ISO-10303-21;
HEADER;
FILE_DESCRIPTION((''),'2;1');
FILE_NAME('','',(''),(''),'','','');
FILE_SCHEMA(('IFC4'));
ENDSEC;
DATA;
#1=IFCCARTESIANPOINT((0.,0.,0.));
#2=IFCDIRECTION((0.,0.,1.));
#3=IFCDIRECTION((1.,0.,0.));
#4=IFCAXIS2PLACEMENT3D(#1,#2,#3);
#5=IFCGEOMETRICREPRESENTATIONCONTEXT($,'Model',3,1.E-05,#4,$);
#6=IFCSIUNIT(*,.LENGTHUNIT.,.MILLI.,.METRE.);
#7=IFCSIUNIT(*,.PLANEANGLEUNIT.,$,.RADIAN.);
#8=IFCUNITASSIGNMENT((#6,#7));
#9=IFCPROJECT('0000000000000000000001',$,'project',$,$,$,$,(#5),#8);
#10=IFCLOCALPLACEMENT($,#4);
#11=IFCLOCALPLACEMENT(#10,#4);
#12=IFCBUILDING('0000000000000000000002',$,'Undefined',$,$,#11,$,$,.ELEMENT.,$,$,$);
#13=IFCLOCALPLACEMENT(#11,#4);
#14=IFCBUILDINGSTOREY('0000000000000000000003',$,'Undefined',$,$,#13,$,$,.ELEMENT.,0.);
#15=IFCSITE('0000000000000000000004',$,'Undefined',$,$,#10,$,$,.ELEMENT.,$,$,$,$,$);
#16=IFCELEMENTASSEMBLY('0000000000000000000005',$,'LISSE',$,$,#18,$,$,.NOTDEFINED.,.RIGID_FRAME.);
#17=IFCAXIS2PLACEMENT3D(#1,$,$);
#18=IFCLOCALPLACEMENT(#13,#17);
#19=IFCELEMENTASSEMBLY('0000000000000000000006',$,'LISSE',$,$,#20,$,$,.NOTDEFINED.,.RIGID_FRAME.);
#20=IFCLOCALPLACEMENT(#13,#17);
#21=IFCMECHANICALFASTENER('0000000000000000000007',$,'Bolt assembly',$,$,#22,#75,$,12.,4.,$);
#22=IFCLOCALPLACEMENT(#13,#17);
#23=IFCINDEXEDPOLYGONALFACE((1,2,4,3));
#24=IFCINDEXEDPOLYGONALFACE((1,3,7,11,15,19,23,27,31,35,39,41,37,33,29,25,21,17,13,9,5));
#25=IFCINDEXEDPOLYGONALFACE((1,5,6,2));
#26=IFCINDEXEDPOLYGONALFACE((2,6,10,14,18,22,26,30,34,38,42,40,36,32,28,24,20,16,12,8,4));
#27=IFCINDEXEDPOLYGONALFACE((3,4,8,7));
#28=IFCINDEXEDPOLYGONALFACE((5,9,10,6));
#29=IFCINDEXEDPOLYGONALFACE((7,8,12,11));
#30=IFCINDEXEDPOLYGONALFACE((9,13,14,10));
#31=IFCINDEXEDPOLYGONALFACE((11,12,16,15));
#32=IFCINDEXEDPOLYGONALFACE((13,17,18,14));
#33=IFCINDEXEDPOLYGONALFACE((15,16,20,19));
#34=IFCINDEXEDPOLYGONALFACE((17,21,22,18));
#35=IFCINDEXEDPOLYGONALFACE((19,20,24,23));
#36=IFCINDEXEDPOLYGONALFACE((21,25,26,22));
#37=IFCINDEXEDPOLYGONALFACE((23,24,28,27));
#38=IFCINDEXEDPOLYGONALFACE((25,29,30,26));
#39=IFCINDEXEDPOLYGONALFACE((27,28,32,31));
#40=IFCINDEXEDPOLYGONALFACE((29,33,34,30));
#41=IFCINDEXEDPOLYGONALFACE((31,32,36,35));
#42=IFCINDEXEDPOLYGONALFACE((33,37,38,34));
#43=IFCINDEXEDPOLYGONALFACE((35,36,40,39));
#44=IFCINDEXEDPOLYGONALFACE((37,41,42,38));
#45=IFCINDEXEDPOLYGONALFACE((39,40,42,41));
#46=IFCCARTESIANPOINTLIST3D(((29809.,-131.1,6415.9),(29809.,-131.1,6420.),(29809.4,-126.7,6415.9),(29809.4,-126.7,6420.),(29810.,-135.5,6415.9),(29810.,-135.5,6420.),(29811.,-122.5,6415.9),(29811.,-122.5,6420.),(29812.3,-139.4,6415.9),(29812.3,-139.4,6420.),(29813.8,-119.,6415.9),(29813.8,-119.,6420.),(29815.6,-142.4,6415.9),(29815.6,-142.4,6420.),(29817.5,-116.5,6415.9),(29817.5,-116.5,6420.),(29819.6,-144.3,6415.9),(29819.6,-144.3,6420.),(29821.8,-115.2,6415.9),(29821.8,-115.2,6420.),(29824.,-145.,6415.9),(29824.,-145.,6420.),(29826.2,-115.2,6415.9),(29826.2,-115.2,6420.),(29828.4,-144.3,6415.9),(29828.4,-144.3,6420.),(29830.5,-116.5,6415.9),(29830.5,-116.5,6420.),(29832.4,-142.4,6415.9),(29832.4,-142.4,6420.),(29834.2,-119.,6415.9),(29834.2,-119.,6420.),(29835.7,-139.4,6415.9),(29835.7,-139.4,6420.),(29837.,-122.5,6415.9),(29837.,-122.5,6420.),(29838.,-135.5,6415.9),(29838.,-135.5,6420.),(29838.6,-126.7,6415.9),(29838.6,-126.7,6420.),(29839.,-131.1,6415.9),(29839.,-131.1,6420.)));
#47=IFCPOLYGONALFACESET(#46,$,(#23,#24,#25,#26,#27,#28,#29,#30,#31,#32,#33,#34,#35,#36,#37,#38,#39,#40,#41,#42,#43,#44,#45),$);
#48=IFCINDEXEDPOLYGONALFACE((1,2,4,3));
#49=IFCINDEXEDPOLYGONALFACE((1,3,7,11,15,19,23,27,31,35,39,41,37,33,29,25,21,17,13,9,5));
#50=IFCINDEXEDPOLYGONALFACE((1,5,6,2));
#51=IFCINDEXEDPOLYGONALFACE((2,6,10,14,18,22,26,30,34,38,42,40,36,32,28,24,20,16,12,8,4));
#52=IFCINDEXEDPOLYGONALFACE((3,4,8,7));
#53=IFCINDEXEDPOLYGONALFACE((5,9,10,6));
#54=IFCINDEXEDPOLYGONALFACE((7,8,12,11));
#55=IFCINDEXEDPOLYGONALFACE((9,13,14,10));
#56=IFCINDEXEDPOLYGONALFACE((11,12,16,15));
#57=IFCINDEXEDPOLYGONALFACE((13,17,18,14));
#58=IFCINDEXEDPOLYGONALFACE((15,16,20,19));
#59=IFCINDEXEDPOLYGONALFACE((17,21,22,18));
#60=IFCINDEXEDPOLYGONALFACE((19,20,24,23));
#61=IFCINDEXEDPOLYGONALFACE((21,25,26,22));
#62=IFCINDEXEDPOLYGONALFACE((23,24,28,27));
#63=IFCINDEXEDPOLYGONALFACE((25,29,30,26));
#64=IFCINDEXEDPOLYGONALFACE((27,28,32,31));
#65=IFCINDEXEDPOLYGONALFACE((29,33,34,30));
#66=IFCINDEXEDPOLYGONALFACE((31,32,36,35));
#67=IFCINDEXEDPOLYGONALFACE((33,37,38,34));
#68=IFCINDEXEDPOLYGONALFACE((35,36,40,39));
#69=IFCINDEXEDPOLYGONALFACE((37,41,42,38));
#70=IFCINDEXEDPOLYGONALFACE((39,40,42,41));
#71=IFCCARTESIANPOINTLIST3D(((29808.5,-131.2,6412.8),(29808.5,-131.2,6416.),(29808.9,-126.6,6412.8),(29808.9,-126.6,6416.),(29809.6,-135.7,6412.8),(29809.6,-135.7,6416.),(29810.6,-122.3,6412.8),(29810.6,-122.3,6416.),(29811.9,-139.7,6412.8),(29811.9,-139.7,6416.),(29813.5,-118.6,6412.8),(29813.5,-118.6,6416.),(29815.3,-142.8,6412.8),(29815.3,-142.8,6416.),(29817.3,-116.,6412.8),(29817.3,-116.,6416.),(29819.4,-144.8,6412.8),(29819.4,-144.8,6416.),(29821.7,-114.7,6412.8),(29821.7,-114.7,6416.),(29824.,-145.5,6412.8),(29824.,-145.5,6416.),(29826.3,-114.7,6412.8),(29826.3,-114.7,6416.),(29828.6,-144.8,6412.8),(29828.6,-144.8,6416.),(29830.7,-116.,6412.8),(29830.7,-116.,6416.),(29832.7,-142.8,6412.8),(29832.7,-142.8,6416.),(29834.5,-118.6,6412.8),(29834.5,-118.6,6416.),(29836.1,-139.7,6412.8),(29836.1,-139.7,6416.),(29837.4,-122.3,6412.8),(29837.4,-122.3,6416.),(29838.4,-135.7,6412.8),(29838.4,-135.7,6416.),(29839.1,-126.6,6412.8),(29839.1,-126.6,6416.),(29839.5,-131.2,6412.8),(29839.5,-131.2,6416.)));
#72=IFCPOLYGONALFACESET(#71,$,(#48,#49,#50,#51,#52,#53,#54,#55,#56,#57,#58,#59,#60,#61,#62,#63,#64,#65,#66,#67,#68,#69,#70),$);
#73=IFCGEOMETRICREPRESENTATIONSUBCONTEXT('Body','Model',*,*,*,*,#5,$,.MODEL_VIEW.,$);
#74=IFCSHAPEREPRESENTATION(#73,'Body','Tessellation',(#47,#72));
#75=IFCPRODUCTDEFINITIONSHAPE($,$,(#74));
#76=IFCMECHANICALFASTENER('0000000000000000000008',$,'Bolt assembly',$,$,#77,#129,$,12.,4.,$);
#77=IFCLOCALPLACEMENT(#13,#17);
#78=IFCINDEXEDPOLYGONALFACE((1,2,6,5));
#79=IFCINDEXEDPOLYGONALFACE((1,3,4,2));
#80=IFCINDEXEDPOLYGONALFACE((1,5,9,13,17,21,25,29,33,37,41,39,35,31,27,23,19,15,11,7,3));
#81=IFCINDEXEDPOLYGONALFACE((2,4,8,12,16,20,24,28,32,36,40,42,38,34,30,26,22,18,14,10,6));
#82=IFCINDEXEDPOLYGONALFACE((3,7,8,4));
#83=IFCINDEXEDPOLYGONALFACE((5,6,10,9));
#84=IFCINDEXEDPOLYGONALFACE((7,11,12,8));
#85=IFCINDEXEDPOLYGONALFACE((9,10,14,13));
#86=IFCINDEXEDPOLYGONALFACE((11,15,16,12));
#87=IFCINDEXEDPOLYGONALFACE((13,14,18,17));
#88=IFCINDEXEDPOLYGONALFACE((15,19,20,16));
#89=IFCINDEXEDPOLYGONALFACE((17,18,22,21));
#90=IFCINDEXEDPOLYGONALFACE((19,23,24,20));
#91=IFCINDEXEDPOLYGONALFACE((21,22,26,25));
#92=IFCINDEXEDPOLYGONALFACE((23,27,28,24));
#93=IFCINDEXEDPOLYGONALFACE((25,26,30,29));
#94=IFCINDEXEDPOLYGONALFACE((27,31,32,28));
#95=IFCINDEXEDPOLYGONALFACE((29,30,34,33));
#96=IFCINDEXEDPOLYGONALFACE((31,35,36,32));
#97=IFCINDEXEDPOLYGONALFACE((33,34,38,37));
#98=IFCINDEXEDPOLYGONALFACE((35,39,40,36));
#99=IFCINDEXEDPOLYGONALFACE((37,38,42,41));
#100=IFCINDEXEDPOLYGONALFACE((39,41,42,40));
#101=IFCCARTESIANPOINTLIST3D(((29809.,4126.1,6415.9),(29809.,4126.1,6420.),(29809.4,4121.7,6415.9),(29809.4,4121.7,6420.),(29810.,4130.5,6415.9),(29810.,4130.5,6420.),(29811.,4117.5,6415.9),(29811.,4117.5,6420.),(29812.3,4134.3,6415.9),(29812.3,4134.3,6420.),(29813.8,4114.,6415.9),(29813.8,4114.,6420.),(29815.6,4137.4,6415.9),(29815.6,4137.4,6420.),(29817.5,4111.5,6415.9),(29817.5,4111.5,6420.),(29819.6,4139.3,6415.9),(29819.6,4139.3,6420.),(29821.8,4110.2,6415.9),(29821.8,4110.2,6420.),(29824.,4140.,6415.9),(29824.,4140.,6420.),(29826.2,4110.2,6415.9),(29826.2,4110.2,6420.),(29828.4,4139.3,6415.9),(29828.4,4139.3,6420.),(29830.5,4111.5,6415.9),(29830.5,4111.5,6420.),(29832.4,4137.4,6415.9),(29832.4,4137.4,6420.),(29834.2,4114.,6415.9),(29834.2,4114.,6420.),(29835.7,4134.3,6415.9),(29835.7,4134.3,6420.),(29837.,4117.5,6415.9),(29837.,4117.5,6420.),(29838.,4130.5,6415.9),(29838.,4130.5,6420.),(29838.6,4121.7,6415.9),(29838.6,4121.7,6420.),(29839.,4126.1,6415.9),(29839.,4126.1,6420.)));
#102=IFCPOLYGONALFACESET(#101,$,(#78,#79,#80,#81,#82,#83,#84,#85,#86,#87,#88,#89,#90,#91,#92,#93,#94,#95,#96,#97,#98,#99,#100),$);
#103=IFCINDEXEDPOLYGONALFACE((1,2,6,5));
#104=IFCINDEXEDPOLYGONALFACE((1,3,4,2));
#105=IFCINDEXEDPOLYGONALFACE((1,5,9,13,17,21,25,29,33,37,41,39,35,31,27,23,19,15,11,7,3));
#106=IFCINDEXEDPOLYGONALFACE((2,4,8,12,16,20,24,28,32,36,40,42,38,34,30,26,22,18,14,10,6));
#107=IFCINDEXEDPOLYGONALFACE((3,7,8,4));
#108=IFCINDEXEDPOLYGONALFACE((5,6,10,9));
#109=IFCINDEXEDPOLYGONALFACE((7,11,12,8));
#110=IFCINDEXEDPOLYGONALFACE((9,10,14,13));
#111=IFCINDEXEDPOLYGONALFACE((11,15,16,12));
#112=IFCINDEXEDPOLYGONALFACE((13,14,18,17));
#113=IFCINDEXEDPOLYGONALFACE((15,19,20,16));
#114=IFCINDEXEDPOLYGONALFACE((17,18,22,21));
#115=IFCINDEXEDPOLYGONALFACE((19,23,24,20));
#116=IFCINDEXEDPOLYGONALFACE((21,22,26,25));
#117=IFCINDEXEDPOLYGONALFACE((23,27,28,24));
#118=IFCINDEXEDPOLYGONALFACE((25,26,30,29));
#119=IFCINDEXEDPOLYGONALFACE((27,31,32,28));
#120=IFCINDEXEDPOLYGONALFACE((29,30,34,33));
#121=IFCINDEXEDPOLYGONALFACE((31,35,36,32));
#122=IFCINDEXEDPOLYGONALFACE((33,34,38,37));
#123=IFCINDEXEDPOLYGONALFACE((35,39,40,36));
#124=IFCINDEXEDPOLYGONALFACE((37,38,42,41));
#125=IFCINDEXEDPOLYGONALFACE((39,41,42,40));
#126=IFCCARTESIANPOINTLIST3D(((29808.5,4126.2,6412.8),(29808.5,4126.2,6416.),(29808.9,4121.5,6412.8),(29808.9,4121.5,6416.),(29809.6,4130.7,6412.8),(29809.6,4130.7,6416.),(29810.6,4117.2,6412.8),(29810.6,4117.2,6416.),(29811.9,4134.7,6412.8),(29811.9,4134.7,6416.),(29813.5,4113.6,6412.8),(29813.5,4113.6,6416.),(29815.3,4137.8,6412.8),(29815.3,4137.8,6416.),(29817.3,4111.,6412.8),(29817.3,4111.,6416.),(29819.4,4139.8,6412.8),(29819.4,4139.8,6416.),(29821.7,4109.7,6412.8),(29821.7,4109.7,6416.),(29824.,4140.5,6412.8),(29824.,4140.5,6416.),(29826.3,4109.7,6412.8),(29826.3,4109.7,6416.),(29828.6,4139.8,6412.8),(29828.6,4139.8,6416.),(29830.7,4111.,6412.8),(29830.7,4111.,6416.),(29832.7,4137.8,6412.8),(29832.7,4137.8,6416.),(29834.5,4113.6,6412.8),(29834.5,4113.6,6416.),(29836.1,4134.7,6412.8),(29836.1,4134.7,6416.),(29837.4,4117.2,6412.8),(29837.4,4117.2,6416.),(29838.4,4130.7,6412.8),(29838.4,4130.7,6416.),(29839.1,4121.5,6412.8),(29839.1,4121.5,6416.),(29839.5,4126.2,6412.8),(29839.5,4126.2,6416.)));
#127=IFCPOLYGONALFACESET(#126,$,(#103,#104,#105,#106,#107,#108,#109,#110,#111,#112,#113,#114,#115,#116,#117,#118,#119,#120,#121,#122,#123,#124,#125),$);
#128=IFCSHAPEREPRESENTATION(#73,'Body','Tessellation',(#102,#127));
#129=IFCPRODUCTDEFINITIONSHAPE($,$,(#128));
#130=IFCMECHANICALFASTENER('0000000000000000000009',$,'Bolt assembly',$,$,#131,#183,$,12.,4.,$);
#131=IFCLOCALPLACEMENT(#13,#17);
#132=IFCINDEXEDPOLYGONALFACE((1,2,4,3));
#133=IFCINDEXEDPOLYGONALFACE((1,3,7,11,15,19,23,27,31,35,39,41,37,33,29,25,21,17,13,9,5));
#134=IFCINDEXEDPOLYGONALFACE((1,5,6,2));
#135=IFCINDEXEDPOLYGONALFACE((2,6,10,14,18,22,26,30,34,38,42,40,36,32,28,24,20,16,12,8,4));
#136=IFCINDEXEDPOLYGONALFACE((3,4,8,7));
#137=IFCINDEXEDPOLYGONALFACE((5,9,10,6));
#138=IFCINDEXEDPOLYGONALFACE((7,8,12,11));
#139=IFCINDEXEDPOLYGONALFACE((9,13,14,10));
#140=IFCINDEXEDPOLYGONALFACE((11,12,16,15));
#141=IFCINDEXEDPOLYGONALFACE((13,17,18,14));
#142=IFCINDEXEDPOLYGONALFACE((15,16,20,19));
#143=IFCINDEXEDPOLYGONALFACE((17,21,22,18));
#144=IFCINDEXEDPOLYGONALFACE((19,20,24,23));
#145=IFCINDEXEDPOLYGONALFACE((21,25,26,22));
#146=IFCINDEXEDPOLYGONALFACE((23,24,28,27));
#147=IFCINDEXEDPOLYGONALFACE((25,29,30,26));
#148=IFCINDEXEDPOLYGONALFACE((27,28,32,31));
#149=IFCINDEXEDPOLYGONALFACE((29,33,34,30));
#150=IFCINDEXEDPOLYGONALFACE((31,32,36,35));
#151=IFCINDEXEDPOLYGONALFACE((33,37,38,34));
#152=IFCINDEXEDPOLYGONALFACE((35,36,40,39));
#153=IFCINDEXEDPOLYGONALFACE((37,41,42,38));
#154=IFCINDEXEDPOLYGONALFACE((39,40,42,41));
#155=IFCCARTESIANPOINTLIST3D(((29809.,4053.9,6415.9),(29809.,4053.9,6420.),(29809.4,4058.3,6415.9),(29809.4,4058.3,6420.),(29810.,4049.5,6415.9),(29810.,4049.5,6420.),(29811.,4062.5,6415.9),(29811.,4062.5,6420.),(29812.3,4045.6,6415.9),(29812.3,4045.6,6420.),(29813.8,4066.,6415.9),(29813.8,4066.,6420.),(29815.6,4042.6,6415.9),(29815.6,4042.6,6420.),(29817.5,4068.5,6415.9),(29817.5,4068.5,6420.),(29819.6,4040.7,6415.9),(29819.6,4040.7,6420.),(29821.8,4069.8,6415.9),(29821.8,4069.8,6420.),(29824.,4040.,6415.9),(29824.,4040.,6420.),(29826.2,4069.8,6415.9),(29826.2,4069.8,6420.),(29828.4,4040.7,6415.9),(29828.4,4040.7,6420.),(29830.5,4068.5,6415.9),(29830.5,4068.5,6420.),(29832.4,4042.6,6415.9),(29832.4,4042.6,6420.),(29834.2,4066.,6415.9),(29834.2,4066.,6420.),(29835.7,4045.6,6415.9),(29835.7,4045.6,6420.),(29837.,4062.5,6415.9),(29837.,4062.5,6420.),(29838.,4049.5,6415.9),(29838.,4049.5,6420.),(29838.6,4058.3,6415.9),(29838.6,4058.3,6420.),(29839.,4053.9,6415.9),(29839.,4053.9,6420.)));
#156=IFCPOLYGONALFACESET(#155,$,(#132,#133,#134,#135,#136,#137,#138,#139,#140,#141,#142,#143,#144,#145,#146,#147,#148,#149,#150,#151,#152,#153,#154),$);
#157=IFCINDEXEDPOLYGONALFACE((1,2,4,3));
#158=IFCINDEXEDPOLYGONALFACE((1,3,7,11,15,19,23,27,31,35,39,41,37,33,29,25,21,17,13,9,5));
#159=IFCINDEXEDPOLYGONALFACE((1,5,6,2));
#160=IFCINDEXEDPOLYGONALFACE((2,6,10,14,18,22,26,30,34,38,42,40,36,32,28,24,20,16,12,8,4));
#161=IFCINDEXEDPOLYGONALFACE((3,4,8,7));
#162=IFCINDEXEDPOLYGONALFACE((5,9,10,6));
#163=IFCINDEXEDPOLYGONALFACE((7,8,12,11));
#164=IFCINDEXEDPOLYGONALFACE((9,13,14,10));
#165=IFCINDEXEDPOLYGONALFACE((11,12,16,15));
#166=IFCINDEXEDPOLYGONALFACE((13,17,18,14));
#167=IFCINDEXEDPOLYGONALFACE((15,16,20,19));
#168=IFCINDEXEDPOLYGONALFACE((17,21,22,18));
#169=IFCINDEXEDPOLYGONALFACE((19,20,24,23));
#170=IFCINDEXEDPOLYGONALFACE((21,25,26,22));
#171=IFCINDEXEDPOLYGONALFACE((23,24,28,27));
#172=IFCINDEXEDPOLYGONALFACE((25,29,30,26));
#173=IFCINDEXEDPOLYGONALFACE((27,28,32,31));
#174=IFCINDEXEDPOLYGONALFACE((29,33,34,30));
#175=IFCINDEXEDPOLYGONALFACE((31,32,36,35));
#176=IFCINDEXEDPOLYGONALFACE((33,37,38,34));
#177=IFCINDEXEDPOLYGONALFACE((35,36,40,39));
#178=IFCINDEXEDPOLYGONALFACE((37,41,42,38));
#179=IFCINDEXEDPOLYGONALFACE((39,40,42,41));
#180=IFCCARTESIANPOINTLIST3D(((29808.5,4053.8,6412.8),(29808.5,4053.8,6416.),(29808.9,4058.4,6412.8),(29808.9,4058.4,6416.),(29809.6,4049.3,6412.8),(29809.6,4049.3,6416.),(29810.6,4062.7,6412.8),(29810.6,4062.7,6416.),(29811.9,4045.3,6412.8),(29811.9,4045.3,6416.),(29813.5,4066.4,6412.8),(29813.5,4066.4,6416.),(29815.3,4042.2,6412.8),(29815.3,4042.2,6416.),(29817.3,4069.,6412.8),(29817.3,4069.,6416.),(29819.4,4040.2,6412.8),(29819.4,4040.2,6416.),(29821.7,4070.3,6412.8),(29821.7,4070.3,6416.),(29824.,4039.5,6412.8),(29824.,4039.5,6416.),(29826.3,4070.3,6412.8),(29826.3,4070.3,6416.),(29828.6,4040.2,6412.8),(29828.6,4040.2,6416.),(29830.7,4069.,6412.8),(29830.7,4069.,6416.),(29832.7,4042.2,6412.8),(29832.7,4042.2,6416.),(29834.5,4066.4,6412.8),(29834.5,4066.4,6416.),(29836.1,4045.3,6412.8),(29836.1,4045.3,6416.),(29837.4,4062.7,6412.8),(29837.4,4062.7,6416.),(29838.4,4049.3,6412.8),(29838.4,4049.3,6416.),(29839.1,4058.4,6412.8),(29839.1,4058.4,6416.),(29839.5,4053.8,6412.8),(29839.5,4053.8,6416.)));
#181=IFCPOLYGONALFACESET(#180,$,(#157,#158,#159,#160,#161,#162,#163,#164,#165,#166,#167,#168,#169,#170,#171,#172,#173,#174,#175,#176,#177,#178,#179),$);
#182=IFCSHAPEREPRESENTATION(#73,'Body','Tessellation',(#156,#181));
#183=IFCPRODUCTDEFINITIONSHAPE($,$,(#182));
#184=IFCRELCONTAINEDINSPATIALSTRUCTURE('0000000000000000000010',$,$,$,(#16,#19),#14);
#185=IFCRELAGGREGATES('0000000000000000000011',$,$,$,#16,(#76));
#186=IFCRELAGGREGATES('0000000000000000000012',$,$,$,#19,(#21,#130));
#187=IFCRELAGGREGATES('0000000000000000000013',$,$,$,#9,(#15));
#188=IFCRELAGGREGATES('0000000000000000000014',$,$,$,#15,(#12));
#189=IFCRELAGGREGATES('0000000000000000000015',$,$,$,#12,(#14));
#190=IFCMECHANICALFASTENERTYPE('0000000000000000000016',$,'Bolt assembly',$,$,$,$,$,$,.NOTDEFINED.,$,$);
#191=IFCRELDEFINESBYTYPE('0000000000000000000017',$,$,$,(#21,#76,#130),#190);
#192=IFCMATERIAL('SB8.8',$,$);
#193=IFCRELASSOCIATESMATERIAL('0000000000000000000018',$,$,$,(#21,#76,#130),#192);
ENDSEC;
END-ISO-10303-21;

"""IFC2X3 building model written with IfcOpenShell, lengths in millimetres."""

from ifc_helpers import new_model, si_unit, frame, origin_with_axes, origin_2d_with_axis, place, context, subcontext, project, spatial, circle, extrude, source, transform, mapped, material, type_object, element, aggregate, save


model = new_model("IFC2X3")

# Units and contexts
model_context = context("Model", 3, precision=1e-05, world=origin_with_axes())
body_context = subcontext(model_context, "Body", "Model", "MODEL_VIEW")
ifc_project = project(units=[si_unit("LENGTHUNIT", "METRE", prefix="MILLI"), si_unit("PLANEANGLEUNIT", "RADIAN")], contexts=[model_context])

# Site, building, storey
site_placement = place(None, origin_with_axes())
site = spatial("IfcSite", under=ifc_project, at=site_placement, Name="Undefined", CompositionType="ELEMENT")
building_placement = place(site_placement, origin_with_axes())
building = spatial("IfcBuilding", under=site, at=building_placement, Name="Undefined", CompositionType="ELEMENT")
storey_placement = place(building_placement, origin_with_axes())
storey = spatial("IfcBuildingStorey", under=building, at=storey_placement, Name="Undefined", CompositionType="ELEMENT", Elevation=0.0)

# Element assemblies
assembly_1_placement = place(storey_placement, origin_with_axes())
assembly_1 = element("IfcElementAssembly", 1, at=assembly_1_placement, inside=storey, Name="LISSE", AssemblyPlace="NOTDEFINED", PredefinedType="RIGID_FRAME")
assembly_2_placement = place(storey_placement, origin_with_axes())
assembly_2 = element("IfcElementAssembly", 2, at=assembly_2_placement, inside=storey, Name="LISSE", AssemblyPlace="NOTDEFINED", PredefinedType="RIGID_FRAME")

# Shared definitions
ifc_material_1 = material(Name="SB8.8")
mechanical_fastener_type = type_object("IfcMechanicalFastenerType", Name="Bolt assembly")

# Mechanical fasteners
shared_shape_1 = source(origin_with_axes(), body_context, "Body", "SweptSolid", [
    extrude(circle(Radius=15.0, at=origin_2d_with_axis()), frame((0.0, -10.0, 0.0), z_axis=(0.0, 1.0, 0.0), x_axis=(1.0, 0.0, 0.0)), (0.0, 0.0, 1.0), 4.1),
    extrude(circle(Radius=15.5, at=origin_2d_with_axis()), frame((0.0, -6.0, 0.0), z_axis=(0.0, 1.0, 0.0), x_axis=(1.0, 0.0, 0.0)), (0.0, 0.0, 1.0), 3.2),
])
mechanical_fastener_1_placement = place(assembly_2_placement, frame((29824.0, -130.0, 6410.0), z_axis=(1.0, 0.0, 0.0), x_axis=(0.0, -1.0, 0.0)))
mechanical_fastener_1 = element("IfcMechanicalFastener", 3, at=mechanical_fastener_1_placement, type_object=mechanical_fastener_type, material=ifc_material_1, Name="Bolt assembly", NominalDiameter=12.0, NominalLength=4.0, context=body_context, shape_type="MappedRepresentation", body=[
    mapped(shared_shape_1, transform((0.0, 0.0, 0.0))),
])
mechanical_fastener_2_placement = place(assembly_1_placement, frame((29824.0, 4125.0, 6410.0), z_axis=(-1.0, 0.0, 0.0), x_axis=(0.0, 1.0, 0.0)))
mechanical_fastener_2 = element("IfcMechanicalFastener", 4, at=mechanical_fastener_2_placement, type_object=mechanical_fastener_type, material=ifc_material_1, Name="Bolt assembly", NominalDiameter=12.0, NominalLength=4.0, context=body_context, shape_type="MappedRepresentation", body=[
    mapped(shared_shape_1, transform((0.0, 0.0, 0.0))),
])
aggregate(assembly_1, [mechanical_fastener_2])
mechanical_fastener_3_placement = place(assembly_2_placement, frame((29824.0, 4055.0, 6410.0), z_axis=(1.0, 0.0, 0.0), x_axis=(0.0, -1.0, 0.0)))
mechanical_fastener_3 = element("IfcMechanicalFastener", 5, at=mechanical_fastener_3_placement, type_object=mechanical_fastener_type, material=ifc_material_1, Name="Bolt assembly", NominalDiameter=12.0, NominalLength=4.0, context=body_context, shape_type="MappedRepresentation", body=[
    mapped(shared_shape_1, transform((0.0, 0.0, 0.0))),
])
aggregate(assembly_2, [mechanical_fastener_1, mechanical_fastener_3])

save(model, "model.ifc")
